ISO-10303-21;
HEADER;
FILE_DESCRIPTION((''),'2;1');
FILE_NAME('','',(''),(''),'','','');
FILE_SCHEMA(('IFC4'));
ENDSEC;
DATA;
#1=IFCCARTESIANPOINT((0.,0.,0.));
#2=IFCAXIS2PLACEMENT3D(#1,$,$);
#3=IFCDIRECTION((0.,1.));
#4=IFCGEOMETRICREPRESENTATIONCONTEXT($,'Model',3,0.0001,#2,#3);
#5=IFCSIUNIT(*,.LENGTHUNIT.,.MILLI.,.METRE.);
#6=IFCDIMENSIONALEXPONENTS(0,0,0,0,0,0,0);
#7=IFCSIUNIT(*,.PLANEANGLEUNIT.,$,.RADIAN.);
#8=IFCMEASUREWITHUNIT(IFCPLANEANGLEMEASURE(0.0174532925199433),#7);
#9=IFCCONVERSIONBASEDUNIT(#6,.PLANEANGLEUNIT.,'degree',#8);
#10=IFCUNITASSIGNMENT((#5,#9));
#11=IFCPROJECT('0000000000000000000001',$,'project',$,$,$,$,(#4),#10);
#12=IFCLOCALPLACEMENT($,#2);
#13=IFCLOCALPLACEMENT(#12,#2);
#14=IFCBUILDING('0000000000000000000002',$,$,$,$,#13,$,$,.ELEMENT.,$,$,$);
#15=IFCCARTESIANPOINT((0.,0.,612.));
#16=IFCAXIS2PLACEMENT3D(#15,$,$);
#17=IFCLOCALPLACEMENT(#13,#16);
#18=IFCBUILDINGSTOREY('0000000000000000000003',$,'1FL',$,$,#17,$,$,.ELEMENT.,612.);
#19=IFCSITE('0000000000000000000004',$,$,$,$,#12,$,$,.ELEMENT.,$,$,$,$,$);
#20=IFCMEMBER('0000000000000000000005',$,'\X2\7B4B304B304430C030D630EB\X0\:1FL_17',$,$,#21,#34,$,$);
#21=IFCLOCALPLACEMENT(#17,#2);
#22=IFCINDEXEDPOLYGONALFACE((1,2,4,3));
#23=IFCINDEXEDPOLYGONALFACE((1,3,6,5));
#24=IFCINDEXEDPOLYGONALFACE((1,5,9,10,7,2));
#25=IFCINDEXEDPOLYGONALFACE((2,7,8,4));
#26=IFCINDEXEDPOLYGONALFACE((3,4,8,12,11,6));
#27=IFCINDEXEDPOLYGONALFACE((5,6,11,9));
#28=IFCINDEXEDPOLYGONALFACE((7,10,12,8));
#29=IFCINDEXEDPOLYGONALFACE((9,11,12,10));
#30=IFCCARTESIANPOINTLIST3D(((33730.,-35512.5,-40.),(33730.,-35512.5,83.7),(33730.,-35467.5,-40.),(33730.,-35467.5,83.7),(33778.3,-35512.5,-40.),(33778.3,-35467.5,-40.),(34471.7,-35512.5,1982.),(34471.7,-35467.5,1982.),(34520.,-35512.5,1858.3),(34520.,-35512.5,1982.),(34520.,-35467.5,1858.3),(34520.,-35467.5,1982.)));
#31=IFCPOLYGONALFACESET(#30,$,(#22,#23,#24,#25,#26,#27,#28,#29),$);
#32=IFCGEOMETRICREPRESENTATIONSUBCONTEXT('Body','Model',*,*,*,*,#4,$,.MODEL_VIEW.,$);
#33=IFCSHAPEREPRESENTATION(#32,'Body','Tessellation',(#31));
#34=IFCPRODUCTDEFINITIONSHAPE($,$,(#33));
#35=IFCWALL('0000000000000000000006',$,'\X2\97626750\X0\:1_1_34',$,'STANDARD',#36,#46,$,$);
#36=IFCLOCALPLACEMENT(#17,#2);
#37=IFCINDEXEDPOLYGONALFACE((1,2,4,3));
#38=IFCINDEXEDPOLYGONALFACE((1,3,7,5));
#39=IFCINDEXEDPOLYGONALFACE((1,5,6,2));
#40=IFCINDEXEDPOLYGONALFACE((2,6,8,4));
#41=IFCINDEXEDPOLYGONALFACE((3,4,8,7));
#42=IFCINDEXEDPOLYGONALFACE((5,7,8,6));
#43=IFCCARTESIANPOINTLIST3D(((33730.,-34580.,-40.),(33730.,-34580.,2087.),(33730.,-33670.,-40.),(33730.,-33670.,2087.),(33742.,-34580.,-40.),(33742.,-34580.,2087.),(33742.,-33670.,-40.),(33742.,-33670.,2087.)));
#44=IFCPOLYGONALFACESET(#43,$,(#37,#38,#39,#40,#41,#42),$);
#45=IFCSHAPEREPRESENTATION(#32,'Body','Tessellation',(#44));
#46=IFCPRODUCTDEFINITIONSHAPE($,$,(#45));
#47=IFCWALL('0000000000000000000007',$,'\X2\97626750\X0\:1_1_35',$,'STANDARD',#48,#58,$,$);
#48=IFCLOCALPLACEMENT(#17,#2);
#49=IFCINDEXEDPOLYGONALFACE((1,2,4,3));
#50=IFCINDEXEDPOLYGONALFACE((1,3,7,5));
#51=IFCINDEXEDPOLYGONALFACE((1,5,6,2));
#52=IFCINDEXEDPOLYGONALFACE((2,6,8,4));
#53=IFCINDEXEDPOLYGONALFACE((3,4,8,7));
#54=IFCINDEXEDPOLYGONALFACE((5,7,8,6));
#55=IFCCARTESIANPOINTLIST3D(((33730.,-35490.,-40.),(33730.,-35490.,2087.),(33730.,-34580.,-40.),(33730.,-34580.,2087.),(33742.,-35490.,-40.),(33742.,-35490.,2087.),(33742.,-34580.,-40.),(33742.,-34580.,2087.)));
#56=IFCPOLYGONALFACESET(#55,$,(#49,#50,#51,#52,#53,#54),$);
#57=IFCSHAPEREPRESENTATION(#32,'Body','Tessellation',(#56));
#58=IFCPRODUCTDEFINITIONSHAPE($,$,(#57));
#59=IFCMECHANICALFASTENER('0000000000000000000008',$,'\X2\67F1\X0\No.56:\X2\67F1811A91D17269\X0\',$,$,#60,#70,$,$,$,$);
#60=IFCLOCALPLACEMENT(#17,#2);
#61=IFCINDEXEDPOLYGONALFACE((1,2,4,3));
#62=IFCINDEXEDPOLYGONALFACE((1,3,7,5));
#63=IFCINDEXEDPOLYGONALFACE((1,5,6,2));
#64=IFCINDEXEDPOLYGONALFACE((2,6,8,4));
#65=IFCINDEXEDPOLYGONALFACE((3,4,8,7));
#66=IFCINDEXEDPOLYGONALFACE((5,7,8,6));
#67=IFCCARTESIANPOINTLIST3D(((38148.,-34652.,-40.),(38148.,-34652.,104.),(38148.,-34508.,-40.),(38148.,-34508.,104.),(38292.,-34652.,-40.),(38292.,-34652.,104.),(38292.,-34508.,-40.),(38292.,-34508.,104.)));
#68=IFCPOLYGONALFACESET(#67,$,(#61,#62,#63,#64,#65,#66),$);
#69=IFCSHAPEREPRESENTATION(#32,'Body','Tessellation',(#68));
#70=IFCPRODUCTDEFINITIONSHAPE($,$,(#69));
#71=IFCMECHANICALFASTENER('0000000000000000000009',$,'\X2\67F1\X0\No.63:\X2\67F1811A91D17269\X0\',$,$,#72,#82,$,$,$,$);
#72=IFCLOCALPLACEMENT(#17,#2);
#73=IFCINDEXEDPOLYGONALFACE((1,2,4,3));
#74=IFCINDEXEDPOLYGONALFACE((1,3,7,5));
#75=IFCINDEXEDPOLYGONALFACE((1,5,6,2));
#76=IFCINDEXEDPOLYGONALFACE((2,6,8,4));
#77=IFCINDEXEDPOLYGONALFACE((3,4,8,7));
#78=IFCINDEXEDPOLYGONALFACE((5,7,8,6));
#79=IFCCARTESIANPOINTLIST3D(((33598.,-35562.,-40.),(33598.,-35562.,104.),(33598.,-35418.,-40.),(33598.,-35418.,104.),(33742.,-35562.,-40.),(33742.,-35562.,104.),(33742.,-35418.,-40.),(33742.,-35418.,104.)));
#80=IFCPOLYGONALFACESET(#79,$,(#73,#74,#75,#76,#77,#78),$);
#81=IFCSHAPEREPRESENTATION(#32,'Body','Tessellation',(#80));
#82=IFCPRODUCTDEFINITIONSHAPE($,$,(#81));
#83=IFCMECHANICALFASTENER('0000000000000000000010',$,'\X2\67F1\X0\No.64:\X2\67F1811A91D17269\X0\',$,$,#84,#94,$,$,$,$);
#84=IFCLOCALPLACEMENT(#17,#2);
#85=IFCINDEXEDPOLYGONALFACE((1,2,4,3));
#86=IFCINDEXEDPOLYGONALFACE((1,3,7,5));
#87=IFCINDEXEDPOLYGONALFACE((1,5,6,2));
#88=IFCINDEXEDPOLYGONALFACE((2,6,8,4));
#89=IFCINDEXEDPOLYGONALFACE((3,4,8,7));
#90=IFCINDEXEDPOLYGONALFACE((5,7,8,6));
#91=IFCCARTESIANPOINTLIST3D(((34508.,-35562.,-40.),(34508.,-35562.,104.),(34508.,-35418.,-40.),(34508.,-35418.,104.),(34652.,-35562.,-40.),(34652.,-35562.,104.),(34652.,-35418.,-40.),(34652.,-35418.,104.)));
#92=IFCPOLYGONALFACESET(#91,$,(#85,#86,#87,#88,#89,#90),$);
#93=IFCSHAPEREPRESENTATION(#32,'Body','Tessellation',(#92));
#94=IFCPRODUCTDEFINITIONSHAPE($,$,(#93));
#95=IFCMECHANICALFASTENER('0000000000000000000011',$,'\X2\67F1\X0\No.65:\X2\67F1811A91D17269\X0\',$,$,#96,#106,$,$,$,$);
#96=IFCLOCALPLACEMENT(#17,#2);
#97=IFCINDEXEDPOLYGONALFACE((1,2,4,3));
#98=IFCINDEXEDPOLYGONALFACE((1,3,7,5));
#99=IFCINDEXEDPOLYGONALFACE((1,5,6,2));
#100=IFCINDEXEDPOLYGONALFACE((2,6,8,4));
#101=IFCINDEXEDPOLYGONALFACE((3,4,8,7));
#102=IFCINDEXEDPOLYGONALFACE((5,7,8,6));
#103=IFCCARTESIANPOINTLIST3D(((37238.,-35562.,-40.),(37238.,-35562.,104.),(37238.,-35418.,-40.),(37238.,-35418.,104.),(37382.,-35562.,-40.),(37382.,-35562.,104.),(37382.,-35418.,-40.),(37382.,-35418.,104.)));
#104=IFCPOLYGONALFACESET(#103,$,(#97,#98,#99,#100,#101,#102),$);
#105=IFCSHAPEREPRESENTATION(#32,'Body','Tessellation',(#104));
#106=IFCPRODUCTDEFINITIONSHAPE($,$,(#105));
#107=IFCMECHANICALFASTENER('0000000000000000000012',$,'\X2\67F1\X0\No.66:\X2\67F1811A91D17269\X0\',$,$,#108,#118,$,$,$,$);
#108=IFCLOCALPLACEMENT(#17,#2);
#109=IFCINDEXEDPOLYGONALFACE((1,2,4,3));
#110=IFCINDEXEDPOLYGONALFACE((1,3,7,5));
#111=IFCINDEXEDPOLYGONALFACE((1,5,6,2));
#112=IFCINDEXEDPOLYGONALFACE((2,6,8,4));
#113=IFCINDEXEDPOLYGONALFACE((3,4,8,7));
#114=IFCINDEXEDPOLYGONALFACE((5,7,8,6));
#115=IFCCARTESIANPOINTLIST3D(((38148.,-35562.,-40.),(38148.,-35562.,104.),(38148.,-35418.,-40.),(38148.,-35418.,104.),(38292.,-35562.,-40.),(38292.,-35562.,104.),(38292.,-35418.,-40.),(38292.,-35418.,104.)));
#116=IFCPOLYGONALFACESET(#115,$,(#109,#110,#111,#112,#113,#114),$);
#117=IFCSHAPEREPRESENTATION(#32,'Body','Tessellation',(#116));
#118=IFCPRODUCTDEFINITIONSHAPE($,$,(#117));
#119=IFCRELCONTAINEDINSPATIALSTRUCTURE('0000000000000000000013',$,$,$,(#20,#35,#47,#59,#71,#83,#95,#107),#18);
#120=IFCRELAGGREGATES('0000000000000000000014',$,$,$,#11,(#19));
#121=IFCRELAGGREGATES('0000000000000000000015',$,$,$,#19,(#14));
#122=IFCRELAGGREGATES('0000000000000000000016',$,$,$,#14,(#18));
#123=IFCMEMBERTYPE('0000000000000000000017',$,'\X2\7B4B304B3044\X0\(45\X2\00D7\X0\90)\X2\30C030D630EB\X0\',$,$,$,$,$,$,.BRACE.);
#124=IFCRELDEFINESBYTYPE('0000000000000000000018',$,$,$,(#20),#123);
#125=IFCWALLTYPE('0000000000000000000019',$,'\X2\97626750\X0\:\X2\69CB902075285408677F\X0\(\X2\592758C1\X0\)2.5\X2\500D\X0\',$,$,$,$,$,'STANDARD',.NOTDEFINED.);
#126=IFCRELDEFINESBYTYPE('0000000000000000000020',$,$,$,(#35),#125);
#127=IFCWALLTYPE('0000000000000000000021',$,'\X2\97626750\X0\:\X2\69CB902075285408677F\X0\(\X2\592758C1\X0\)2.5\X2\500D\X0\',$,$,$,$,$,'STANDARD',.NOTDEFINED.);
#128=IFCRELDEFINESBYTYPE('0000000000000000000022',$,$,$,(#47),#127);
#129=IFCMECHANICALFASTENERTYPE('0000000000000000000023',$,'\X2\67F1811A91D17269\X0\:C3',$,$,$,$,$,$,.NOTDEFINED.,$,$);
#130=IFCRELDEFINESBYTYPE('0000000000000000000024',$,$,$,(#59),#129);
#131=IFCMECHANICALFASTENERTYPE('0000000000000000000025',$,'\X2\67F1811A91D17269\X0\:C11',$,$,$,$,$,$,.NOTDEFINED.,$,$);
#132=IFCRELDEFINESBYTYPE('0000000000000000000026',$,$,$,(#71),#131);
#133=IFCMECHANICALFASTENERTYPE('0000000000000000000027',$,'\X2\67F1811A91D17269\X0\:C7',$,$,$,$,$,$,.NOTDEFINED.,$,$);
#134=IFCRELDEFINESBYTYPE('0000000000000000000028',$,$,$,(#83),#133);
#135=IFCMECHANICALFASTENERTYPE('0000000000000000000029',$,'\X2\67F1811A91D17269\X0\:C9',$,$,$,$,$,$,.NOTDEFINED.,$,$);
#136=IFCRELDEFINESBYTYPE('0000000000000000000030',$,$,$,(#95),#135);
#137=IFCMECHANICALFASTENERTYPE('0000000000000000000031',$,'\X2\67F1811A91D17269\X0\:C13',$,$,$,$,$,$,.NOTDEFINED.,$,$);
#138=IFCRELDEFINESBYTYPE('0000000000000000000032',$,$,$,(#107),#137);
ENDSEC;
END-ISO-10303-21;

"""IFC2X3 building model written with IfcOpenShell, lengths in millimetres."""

from ifc_helpers import new_model, entity, si_unit, converted_unit, direction, frame, origin, origin_with_axes, origin_2d, place, context, subcontext, project, spatial, polyline, rectangle, outline, extrude, type_object, element, save


model = new_model("IFC2X3")

# Units and contexts
model_context = context("Model", 3, precision=0.0001, world=origin(), true_north=direction((0.0, 1.0)))
body_context = subcontext(model_context, "Body", "Model", "MODEL_VIEW")
ifc_project = project(units=[si_unit("LENGTHUNIT", "METRE", prefix="MILLI"), converted_unit("PLANEANGLEUNIT", "degree", entity("IfcPlaneAngleMeasure", 0.0174532925199433), si_unit("PLANEANGLEUNIT", "RADIAN"), dimensions=[0, 0, 0, 0, 0, 0, 0])], contexts=[model_context])

# Site, building, storey
site_placement = place(None, origin())
site = spatial("IfcSite", under=ifc_project, at=site_placement, CompositionType="ELEMENT")
building_placement = place(site_placement, origin())
building = spatial("IfcBuilding", under=site, at=building_placement, CompositionType="ELEMENT")
storey_placement = place(building_placement, frame((0.0, 0.0, 612.0)))
storey = spatial("IfcBuildingStorey", under=building, at=storey_placement, Name="1FL", CompositionType="ELEMENT", Elevation=612.0)

# Member
member_type_1 = type_object("IfcMemberType", Name="筋かい(45×90)ダブル", PredefinedType="BRACE")
member_1_placement = place(storey_placement, frame((33730.0, -35490.0, -40.0), z_axis=(0.363913, 0.0, 0.931433), x_axis=(-0.931433, 0.0, 0.363913)))
element("IfcMember", 1, at=member_1_placement, inside=storey, type_object=member_type_1, Name="筋かいダブル:1FL_17", context=body_context, shape_type="SweptSolid", body=[
    extrude(outline(polyline([(0.0, 0.0), (17.6, -45.0), (2055.7, -45.0), (2170.8, 0.0), (2153.3, 45.0), (115.2, 45.0), (0.0, 0.0)])), frame((0.0, -22.5, 0.0), z_axis=(0.0, 1.0, 0.0), x_axis=(0.0, 0.0, 1.0)), (0.0, 0.0, 1.0), 45.0),
])

# Walls
wall_type_1 = type_object("IfcWallType", Name="面材:構造用合板(大壁)2.5倍", ElementType="STANDARD", PredefinedType="NOTDEFINED")
wall_1_placement = place(storey_placement, frame((33742.0, -34125.0, -40.0), z_axis=(-1.0, 0.0, 0.0), x_axis=(0.0, -1.0, 0.0)))
element("IfcWall", 2, at=wall_1_placement, inside=storey, type_object=wall_type_1, Name="面材:1_1_34", ObjectType="STANDARD", context=body_context, shape_type="SweptSolid", body=[
    extrude(outline(polyline([(455.0, 0.0, 0.0), (-455.0, 0.0, 0.0), (-455.0, 2127.0, 0.0), (455.0, 2127.0, 0.0), (455.0, 0.0, 0.0)])), origin_with_axes(), (0.0, 0.0, 1.0), 12.0),
])
wall_type_2 = type_object("IfcWallType", Name="面材:構造用合板(大壁)2.5倍", ElementType="STANDARD", PredefinedType="NOTDEFINED")
wall_2_placement = place(storey_placement, frame((33742.0, -35035.0, -40.0), z_axis=(-1.0, 0.0, 0.0), x_axis=(0.0, -1.0, 0.0)))
element("IfcWall", 3, at=wall_2_placement, inside=storey, type_object=wall_type_2, Name="面材:1_1_35", ObjectType="STANDARD", context=body_context, shape_type="SweptSolid", body=[
    extrude(outline(polyline([(455.0, 0.0, 0.0), (-455.0, 0.0, 0.0), (-455.0, 2127.0, 0.0), (455.0, 2127.0, 0.0), (455.0, 0.0, 0.0)])), origin_with_axes(), (0.0, 0.0, 1.0), 12.0),
])

# Mechanical fasteners
mechanical_fastener_type_1 = type_object("IfcMechanicalFastenerType", Name="柱脚金物:C3")
mechanical_fastener_1_placement = place(storey_placement, frame((38220.0, -34580.0, -40.0)))
element("IfcMechanicalFastener", 4, at=mechanical_fastener_1_placement, inside=storey, type_object=mechanical_fastener_type_1, Name="柱No.56:柱脚金物", context=body_context, shape_type="SweptSolid", body=[
    extrude(rectangle(XDim=144.0, YDim=144.0, at=origin_2d()), origin_with_axes(), (0.0, 0.0, 1.0), 144.0),
])
mechanical_fastener_type_2 = type_object("IfcMechanicalFastenerType", Name="柱脚金物:C11")
mechanical_fastener_2_placement = place(storey_placement, frame((33670.0, -35490.0, -40.0)))
element("IfcMechanicalFastener", 5, at=mechanical_fastener_2_placement, inside=storey, type_object=mechanical_fastener_type_2, Name="柱No.63:柱脚金物", context=body_context, shape_type="SweptSolid", body=[
    extrude(rectangle(XDim=144.0, YDim=144.0, at=origin_2d()), origin_with_axes(), (0.0, 0.0, 1.0), 144.0),
])
mechanical_fastener_type_3 = type_object("IfcMechanicalFastenerType", Name="柱脚金物:C7")
mechanical_fastener_3_placement = place(storey_placement, frame((34580.0, -35490.0, -40.0)))
element("IfcMechanicalFastener", 6, at=mechanical_fastener_3_placement, inside=storey, type_object=mechanical_fastener_type_3, Name="柱No.64:柱脚金物", context=body_context, shape_type="SweptSolid", body=[
    extrude(rectangle(XDim=144.0, YDim=144.0, at=origin_2d()), origin_with_axes(), (0.0, 0.0, 1.0), 144.0),
])
mechanical_fastener_type_4 = type_object("IfcMechanicalFastenerType", Name="柱脚金物:C9")
mechanical_fastener_4_placement = place(storey_placement, frame((37310.0, -35490.0, -40.0)))
element("IfcMechanicalFastener", 7, at=mechanical_fastener_4_placement, inside=storey, type_object=mechanical_fastener_type_4, Name="柱No.65:柱脚金物", context=body_context, shape_type="SweptSolid", body=[
    extrude(rectangle(XDim=144.0, YDim=144.0, at=origin_2d()), origin_with_axes(), (0.0, 0.0, 1.0), 144.0),
])
mechanical_fastener_type_5 = type_object("IfcMechanicalFastenerType", Name="柱脚金物:C13")
mechanical_fastener_5_placement = place(storey_placement, frame((38220.0, -35490.0, -40.0)))
element("IfcMechanicalFastener", 8, at=mechanical_fastener_5_placement, inside=storey, type_object=mechanical_fastener_type_5, Name="柱No.66:柱脚金物", context=body_context, shape_type="SweptSolid", body=[
    extrude(rectangle(XDim=144.0, YDim=144.0, at=origin_2d()), origin_with_axes(), (0.0, 0.0, 1.0), 144.0),
])

save(model, "model.ifc")
